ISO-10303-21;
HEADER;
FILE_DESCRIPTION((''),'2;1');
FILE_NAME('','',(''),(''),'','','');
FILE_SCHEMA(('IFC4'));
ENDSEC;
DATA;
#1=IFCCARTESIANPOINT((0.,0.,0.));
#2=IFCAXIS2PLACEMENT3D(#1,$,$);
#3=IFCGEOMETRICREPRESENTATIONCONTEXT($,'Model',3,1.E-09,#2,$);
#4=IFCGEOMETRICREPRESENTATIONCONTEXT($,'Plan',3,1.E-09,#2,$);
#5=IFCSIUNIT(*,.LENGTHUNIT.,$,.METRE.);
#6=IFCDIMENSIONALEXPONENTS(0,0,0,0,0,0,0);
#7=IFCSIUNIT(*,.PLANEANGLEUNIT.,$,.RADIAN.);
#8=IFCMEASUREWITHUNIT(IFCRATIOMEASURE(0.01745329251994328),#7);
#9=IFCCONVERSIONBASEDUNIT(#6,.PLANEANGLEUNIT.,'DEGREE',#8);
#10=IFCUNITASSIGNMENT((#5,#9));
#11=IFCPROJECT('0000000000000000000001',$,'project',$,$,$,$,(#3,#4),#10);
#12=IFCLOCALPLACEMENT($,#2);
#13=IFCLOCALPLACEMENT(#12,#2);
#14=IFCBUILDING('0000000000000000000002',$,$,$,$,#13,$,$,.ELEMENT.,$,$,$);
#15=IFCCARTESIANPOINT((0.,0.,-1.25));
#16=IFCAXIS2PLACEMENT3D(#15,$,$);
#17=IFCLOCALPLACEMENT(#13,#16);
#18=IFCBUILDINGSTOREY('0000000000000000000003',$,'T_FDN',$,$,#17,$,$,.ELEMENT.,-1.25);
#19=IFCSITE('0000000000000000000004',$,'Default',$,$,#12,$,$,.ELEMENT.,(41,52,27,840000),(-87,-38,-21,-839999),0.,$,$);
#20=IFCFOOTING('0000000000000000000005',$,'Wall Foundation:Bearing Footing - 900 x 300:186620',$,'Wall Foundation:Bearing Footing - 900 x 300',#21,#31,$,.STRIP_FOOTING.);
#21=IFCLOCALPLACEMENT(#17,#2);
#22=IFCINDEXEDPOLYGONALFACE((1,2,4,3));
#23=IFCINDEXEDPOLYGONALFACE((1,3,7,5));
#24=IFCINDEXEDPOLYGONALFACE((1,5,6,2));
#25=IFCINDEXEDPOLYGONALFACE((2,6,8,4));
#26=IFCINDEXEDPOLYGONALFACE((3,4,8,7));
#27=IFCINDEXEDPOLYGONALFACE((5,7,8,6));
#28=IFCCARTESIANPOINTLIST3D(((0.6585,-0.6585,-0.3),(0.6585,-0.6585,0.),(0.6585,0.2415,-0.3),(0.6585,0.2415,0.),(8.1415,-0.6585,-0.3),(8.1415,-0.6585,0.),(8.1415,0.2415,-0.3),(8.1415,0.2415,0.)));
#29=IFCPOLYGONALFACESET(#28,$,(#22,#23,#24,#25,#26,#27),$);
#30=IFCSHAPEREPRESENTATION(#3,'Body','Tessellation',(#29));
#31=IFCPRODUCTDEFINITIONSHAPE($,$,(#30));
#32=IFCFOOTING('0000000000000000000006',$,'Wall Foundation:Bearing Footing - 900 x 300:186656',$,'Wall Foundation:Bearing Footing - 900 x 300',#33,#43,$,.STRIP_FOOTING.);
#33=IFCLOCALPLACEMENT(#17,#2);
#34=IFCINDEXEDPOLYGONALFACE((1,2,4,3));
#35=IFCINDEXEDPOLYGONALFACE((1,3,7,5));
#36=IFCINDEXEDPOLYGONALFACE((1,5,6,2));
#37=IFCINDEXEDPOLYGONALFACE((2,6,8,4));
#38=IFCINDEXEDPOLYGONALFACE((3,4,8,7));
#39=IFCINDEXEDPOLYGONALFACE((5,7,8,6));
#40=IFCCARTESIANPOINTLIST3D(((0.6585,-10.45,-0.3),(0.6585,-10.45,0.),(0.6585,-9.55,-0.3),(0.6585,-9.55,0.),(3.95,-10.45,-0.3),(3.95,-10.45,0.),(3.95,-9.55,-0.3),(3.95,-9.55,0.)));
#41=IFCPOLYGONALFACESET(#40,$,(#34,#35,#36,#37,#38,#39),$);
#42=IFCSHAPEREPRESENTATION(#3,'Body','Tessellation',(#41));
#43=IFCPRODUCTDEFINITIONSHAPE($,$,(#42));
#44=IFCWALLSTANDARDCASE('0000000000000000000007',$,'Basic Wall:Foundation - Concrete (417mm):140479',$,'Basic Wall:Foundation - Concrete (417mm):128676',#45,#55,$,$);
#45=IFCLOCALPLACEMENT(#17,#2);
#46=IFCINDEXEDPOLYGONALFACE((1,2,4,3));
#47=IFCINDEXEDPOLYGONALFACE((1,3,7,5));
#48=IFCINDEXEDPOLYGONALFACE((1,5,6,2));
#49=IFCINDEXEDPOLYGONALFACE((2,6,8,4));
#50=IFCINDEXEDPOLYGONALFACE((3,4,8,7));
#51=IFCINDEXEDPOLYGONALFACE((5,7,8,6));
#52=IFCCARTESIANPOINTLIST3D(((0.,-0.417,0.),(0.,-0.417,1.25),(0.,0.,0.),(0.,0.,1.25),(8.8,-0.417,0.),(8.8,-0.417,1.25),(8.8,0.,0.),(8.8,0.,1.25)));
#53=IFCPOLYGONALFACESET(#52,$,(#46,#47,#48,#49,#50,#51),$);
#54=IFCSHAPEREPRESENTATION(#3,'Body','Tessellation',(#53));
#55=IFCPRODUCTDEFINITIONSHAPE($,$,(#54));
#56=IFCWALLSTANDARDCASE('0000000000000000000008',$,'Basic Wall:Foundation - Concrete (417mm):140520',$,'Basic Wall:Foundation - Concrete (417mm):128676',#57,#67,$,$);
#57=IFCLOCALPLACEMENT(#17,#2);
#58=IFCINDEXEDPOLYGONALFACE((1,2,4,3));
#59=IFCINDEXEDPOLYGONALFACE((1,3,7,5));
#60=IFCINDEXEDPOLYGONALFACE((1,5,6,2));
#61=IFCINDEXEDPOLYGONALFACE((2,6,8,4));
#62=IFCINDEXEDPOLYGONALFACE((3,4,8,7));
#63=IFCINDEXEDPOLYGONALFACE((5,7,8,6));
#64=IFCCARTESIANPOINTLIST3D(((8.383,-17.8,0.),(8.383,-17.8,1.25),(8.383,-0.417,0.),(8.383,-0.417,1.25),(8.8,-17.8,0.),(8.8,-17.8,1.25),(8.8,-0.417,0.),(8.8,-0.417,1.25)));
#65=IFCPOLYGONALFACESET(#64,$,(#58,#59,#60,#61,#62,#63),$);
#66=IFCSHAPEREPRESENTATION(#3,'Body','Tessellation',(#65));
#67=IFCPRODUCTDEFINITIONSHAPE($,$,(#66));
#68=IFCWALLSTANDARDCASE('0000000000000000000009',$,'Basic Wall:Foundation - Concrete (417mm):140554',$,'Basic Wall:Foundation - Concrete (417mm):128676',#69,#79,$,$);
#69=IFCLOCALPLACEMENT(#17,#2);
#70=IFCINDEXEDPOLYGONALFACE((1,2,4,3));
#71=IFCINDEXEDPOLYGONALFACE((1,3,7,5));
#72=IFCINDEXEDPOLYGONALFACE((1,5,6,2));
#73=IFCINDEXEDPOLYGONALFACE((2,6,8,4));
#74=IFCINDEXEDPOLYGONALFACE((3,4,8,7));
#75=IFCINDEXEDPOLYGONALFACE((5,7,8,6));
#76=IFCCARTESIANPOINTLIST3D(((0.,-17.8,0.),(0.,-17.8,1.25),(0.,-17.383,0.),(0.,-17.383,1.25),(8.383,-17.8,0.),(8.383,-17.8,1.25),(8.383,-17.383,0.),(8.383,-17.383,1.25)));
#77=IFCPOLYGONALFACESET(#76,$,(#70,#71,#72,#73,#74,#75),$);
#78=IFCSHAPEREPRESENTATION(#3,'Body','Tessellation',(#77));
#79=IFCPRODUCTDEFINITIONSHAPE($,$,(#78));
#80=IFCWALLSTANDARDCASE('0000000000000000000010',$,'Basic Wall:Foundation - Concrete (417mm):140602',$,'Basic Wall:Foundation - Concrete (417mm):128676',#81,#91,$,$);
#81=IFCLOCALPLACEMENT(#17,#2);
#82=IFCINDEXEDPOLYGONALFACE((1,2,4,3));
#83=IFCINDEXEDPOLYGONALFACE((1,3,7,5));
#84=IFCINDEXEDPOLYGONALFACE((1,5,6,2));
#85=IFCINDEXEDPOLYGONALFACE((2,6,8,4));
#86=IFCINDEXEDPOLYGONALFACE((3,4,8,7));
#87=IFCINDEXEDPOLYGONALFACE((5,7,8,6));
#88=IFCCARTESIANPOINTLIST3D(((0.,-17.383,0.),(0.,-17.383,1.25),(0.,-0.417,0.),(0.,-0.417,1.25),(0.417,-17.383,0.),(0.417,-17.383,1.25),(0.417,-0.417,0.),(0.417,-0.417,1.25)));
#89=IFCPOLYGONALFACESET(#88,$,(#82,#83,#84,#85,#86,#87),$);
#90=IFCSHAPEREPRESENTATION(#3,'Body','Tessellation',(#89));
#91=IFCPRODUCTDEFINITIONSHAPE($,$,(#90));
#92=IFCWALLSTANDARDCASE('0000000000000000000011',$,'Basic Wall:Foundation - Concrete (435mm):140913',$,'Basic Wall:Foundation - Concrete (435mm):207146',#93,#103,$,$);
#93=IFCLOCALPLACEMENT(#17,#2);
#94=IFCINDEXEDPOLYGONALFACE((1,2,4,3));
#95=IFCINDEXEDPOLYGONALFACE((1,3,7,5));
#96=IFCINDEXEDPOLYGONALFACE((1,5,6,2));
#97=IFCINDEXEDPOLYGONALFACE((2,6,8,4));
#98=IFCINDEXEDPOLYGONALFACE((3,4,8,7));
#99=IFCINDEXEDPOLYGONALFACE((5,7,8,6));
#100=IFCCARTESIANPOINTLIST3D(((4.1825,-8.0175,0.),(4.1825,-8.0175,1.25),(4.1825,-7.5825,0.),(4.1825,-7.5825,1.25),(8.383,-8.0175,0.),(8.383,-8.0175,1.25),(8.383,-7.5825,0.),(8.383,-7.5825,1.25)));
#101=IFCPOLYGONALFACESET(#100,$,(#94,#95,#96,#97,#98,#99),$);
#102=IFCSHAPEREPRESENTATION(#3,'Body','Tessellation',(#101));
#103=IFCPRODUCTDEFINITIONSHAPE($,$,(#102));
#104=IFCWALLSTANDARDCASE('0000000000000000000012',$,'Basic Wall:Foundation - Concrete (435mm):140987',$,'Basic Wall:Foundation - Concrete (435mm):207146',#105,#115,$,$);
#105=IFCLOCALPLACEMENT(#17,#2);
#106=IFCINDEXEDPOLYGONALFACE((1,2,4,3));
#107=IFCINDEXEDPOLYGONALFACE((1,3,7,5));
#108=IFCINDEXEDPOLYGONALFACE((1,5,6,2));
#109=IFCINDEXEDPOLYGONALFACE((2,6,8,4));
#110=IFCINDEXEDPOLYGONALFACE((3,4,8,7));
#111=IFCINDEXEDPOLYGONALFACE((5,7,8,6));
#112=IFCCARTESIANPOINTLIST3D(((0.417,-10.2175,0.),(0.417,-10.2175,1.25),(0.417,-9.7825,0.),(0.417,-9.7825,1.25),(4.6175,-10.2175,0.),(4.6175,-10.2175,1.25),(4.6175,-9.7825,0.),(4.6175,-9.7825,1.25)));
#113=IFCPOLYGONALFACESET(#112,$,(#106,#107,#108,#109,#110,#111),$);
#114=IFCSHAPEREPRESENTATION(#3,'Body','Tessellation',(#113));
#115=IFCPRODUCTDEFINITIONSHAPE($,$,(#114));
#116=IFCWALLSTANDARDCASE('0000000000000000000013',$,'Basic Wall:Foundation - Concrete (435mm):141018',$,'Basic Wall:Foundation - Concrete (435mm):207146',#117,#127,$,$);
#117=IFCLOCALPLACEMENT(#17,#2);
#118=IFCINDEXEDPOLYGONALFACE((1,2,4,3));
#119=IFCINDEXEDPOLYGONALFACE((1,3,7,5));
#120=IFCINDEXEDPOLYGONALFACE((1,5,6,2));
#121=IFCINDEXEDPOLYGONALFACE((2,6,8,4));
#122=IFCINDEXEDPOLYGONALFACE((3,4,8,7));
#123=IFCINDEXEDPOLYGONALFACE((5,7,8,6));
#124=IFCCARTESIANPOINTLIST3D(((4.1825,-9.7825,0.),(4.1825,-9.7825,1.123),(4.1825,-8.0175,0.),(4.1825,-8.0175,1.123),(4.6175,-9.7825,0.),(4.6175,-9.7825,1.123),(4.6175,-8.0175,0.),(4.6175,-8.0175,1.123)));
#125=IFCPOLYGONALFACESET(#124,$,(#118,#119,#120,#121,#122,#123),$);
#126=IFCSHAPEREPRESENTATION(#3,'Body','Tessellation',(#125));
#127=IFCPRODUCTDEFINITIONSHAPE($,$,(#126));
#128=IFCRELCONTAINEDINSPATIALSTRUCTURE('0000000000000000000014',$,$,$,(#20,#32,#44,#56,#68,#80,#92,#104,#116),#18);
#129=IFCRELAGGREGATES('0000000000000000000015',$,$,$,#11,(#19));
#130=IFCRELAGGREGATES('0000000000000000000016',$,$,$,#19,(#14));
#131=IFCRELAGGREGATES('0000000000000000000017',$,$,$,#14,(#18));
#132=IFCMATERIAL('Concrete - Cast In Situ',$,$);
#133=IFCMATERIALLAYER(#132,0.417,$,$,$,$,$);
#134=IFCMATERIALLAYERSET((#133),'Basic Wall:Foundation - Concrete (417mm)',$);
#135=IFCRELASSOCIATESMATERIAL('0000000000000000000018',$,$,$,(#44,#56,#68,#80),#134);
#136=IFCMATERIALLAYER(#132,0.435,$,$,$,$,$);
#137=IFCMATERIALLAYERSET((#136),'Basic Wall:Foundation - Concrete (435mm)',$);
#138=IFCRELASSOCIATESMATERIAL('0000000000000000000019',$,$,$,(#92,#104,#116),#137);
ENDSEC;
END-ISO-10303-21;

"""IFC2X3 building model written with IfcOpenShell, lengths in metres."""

from ifc_helpers import new_model, entity, si_unit, converted_unit, frame, frame_2d, origin, origin_2d_with_axis, place, context, project, spatial, rectangle, extrude, material, layer, layer_set, layer_usage, element, save


model = new_model("IFC2X3")

# Units and contexts
model_context = context("Model", 3, precision=1e-09, world=origin())
plan_context = context("Plan", 3, precision=1e-09, world=origin())
ifc_project = project(units=[si_unit("LENGTHUNIT", "METRE"), converted_unit("PLANEANGLEUNIT", "DEGREE", entity("IfcRatioMeasure", 0.01745329251994328), si_unit("PLANEANGLEUNIT", "RADIAN"), dimensions=[0, 0, 0, 0, 0, 0, 0])], contexts=[model_context, plan_context])

# Site, building, storey
site_placement = place(None, origin())
site = spatial("IfcSite", under=ifc_project, at=site_placement, Name="Default", CompositionType="ELEMENT", RefLatitude=(41, 52, 27, 840000), RefLongitude=(-87, -38, -21, -839999), RefElevation=0.0)
building_placement = place(site_placement, origin())
building = spatial("IfcBuilding", under=site, at=building_placement, CompositionType="ELEMENT")
storey_placement = place(building_placement, frame((0.0, 0.0, -1.25)))
storey = spatial("IfcBuildingStorey", under=building, at=storey_placement, Name="T_FDN", CompositionType="ELEMENT", Elevation=-1.25)

# Footings
footing_1_placement = place(storey_placement, origin())
element("IfcFooting", 1, at=footing_1_placement, inside=storey, Name="Wall Foundation:Bearing Footing - 900 x 300:186620", ObjectType="Wall Foundation:Bearing Footing - 900 x 300", PredefinedType="STRIP_FOOTING", context=model_context, shape_type="SweptSolid", body=[
    extrude(rectangle(XDim=7.483, YDim=0.9, at=origin_2d_with_axis()), frame((4.4, -0.2085, -0.3), z_axis=(0.0, 0.0, 1.0), x_axis=(-1.0, 0.0, 0.0)), (0.0, 0.0, 1.0), 0.3),
])
footing_2_placement = place(storey_placement, origin())
element("IfcFooting", 2, at=footing_2_placement, inside=storey, Name="Wall Foundation:Bearing Footing - 900 x 300:186656", ObjectType="Wall Foundation:Bearing Footing - 900 x 300", PredefinedType="STRIP_FOOTING", context=model_context, shape_type="SweptSolid", body=[
    extrude(rectangle(XDim=3.2915, YDim=0.9, at=origin_2d_with_axis()), frame((2.3042, -10.0, -0.3)), (0.0, 0.0, 1.0), 0.3),
])

# Walls
ifc_material = material(Name="Concrete - Cast In Situ")
ifc_layer_1 = layer(ifc_material, 0.417)
ifc_layer_set_1 = layer_set([ifc_layer_1], Name="Basic Wall:Foundation - Concrete (417mm)")
ifc_layer_usage_1 = layer_usage(ifc_layer_set_1, "AXIS2", "NEGATIVE", 0.2085)
wall_1_placement = place(storey_placement, frame((0.0, -0.2085, 0.0)))
element("IfcWallStandardCase", 3, at=wall_1_placement, inside=storey, material=ifc_layer_usage_1, Name="Basic Wall:Foundation - Concrete (417mm):140479", ObjectType="Basic Wall:Foundation - Concrete (417mm):128676", context=model_context, shape_type="SweptSolid", body=[
    extrude(rectangle(XDim=8.8, YDim=0.417, at=frame_2d((4.4, 0.0), x_axis=(-1.0, 0.0))), origin(), (0.0, 0.0, 1.0), 1.25),
])
ifc_layer_usage_2 = layer_usage(ifc_layer_set_1, "AXIS2", "NEGATIVE", 0.2085)
wall_2_placement = place(storey_placement, frame((8.5915, -0.417, 0.0), z_axis=(0.0, 0.0, 1.0), x_axis=(0.0, -1.0, 0.0)))
element("IfcWallStandardCase", 4, at=wall_2_placement, inside=storey, material=ifc_layer_usage_2, Name="Basic Wall:Foundation - Concrete (417mm):140520", ObjectType="Basic Wall:Foundation - Concrete (417mm):128676", context=model_context, shape_type="SweptSolid", body=[
    extrude(rectangle(XDim=17.383, YDim=0.417, at=frame_2d((8.6915, 0.0), x_axis=(-1.0, 0.0))), origin(), (0.0, 0.0, 1.0), 1.25),
])
ifc_layer_usage_3 = layer_usage(ifc_layer_set_1, "AXIS2", "NEGATIVE", 0.2085)
wall_3_placement = place(storey_placement, frame((8.383, -17.5915, 0.0), z_axis=(0.0, 0.0, 1.0), x_axis=(-1.0, 0.0, 0.0)))
element("IfcWallStandardCase", 5, at=wall_3_placement, inside=storey, material=ifc_layer_usage_3, Name="Basic Wall:Foundation - Concrete (417mm):140554", ObjectType="Basic Wall:Foundation - Concrete (417mm):128676", context=model_context, shape_type="SweptSolid", body=[
    extrude(rectangle(XDim=8.383, YDim=0.417, at=frame_2d((4.1915, 0.0), x_axis=(-1.0, 0.0))), origin(), (0.0, 0.0, 1.0), 1.25),
])
ifc_layer_usage_4 = layer_usage(ifc_layer_set_1, "AXIS2", "NEGATIVE", 0.2085)
wall_4_placement = place(storey_placement, frame((0.2085, -17.383, 0.0), z_axis=(0.0, 0.0, 1.0), x_axis=(0.0, 1.0, 0.0)))
element("IfcWallStandardCase", 6, at=wall_4_placement, inside=storey, material=ifc_layer_usage_4, Name="Basic Wall:Foundation - Concrete (417mm):140602", ObjectType="Basic Wall:Foundation - Concrete (417mm):128676", context=model_context, shape_type="SweptSolid", body=[
    extrude(rectangle(XDim=16.966, YDim=0.417, at=frame_2d((8.483, 0.0), x_axis=(-1.0, 0.0))), origin(), (0.0, 0.0, 1.0), 1.25),
])
ifc_layer_2 = layer(ifc_material, 0.435)
ifc_layer_set_2 = layer_set([ifc_layer_2], Name="Basic Wall:Foundation - Concrete (435mm)")
ifc_layer_usage_5 = layer_usage(ifc_layer_set_2, "AXIS2", "NEGATIVE", 0.2175)
wall_5_placement = place(storey_placement, frame((8.383, -7.8, 0.0), z_axis=(0.0, 0.0, 1.0), x_axis=(-1.0, 0.0, 0.0)))
element("IfcWallStandardCase", 7, at=wall_5_placement, inside=storey, material=ifc_layer_usage_5, Name="Basic Wall:Foundation - Concrete (435mm):140913", ObjectType="Basic Wall:Foundation - Concrete (435mm):207146", context=model_context, shape_type="SweptSolid", body=[
    extrude(rectangle(XDim=4.2005, YDim=0.435, at=frame_2d((2.1002, 0.0), x_axis=(-1.0, 0.0))), origin(), (0.0, 0.0, 1.0), 1.25),
])
ifc_layer_usage_6 = layer_usage(ifc_layer_set_2, "AXIS2", "NEGATIVE", 0.2175)
wall_6_placement = place(storey_placement, frame((0.417, -10.0, 0.0)))
element("IfcWallStandardCase", 8, at=wall_6_placement, inside=storey, material=ifc_layer_usage_6, Name="Basic Wall:Foundation - Concrete (435mm):140987", ObjectType="Basic Wall:Foundation - Concrete (435mm):207146", context=model_context, shape_type="SweptSolid", body=[
    extrude(rectangle(XDim=4.2005, YDim=0.435, at=frame_2d((2.1002, 0.0), x_axis=(-1.0, 0.0))), origin(), (0.0, 0.0, 1.0), 1.25),
])
ifc_layer_usage_7 = layer_usage(ifc_layer_set_2, "AXIS2", "NEGATIVE", 0.2175)
wall_7_placement = place(storey_placement, frame((4.4, -9.7825, 0.0), z_axis=(0.0, 0.0, 1.0), x_axis=(0.0, 1.0, 0.0)))
element("IfcWallStandardCase", 9, at=wall_7_placement, inside=storey, material=ifc_layer_usage_7, Name="Basic Wall:Foundation - Concrete (435mm):141018", ObjectType="Basic Wall:Foundation - Concrete (435mm):207146", context=model_context, shape_type="SweptSolid", body=[
    extrude(rectangle(XDim=1.765, YDim=0.435, at=frame_2d((0.8825, 0.0), x_axis=(-1.0, 0.0))), origin(), (0.0, 0.0, 1.0), 1.123),
])

save(model, "model.ifc")
